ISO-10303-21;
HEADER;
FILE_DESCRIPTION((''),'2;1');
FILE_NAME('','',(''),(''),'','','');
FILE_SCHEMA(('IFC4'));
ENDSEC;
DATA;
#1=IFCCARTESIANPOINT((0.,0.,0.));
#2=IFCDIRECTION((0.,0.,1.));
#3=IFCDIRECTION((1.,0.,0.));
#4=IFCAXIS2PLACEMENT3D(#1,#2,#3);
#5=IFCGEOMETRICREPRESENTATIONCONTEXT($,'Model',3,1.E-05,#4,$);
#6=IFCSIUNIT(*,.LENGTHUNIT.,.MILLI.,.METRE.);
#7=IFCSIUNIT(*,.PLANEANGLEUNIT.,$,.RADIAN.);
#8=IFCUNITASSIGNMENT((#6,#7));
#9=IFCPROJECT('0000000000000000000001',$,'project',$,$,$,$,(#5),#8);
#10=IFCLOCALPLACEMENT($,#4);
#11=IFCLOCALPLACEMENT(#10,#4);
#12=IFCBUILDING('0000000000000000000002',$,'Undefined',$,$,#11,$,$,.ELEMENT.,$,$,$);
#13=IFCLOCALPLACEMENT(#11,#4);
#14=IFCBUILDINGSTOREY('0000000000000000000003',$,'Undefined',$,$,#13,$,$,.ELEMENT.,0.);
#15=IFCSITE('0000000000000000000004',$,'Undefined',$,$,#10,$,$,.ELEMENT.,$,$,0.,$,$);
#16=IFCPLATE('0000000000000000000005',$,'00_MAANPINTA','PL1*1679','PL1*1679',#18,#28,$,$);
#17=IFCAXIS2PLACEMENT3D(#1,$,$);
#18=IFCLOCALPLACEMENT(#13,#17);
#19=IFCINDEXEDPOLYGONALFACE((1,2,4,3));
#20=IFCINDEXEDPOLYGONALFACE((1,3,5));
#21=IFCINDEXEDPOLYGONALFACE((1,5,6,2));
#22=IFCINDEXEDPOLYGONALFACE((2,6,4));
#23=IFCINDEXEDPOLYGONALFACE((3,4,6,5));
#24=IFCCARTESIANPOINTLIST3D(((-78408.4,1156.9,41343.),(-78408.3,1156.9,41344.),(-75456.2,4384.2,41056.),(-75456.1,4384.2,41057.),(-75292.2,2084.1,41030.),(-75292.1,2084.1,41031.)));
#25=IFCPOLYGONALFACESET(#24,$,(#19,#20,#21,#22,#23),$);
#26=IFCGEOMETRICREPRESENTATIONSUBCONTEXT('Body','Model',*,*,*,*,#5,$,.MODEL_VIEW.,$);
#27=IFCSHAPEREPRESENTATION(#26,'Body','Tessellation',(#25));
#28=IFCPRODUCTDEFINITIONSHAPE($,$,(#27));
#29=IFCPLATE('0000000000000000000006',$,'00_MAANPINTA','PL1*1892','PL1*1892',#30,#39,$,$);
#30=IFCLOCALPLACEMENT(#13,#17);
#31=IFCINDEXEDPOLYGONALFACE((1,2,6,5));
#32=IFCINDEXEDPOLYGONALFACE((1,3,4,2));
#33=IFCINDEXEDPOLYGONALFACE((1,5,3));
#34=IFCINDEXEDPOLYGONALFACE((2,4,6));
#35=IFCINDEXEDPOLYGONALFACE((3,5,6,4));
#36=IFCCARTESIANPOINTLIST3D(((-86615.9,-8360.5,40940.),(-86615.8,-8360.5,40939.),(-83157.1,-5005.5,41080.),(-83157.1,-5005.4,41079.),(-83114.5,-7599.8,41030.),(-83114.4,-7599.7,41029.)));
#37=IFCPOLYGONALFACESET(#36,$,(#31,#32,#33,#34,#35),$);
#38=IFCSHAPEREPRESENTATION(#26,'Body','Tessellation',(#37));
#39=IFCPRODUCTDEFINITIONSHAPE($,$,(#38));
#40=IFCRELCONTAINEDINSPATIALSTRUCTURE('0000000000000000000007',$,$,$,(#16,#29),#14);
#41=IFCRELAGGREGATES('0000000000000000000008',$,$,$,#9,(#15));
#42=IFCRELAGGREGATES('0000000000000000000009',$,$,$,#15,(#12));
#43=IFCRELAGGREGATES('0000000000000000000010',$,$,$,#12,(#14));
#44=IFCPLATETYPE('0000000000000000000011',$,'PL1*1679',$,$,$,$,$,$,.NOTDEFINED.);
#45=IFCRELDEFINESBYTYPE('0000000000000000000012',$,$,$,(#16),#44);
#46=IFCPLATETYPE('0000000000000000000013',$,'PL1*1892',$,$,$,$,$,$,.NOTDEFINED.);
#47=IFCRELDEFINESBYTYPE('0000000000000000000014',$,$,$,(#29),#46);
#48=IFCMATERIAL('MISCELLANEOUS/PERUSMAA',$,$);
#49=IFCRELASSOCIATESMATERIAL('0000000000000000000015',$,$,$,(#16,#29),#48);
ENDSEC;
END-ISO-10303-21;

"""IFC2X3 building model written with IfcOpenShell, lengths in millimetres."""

from ifc_helpers import new_model, si_unit, frame, origin_with_axes, place, context, subcontext, project, spatial, polyline, outline, extrude, material, type_object, element, save


model = new_model("IFC2X3")

# Units and contexts
model_context = context("Model", 3, precision=1e-05, world=origin_with_axes())
body_context = subcontext(model_context, "Body", "Model", "MODEL_VIEW")
ifc_project = project(units=[si_unit("LENGTHUNIT", "METRE", prefix="MILLI"), si_unit("PLANEANGLEUNIT", "RADIAN")], contexts=[model_context])

# Site, building, storey
site_placement = place(None, origin_with_axes())
site = spatial("IfcSite", under=ifc_project, at=site_placement, Name="Undefined", CompositionType="ELEMENT", RefElevation=0.0)
building_placement = place(site_placement, origin_with_axes())
building = spatial("IfcBuilding", under=site, at=building_placement, Name="Undefined", CompositionType="ELEMENT")
storey_placement = place(building_placement, origin_with_axes())
storey = spatial("IfcBuildingStorey", under=building, at=storey_placement, Name="Undefined", CompositionType="ELEMENT", Elevation=0.0)

# Plates
ifc_material = material(Name="MISCELLANEOUS/PERUSMAA")
plate_type_1 = type_object("IfcPlateType", Name="PL1*1679", PredefinedType="NOTDEFINED")
plate_1_placement = place(storey_placement, frame((-75456.2, 4384.2, 41056.5), z_axis=(-0.101127, 0.004034, -0.994865), x_axis=(0.07113, -0.997403, -0.011275)))
element("IfcPlate", 1, at=plate_1_placement, inside=storey, type_object=plate_type_1, material=ifc_material, Name="00_MAANPINTA", Description="PL1*1679", ObjectType="PL1*1679", context=body_context, shape_type="SweptSolid", body=[
    extrude(outline(polyline([(0.0, 0.0), (2306.1, 0.0), (3005.7, 3190.4), (0.0, 0.0)])), frame((0.0, 0.0, -0.5), z_axis=(0.0, 0.0, 1.0), x_axis=(1.0, 0.0, 0.0)), (0.0, 0.0, 1.0), 1.0),
])
plate_type_2 = type_object("IfcPlateType", Name="PL1*1892", PredefinedType="NOTDEFINED")
plate_2_placement = place(storey_placement, frame((-83157.1, -5005.5, 41079.5), z_axis=(0.021431, 0.019617, -0.999578), x_axis=(0.016426, -0.999679, -0.019267)))
element("IfcPlate", 2, at=plate_2_placement, inside=storey, type_object=plate_type_2, material=ifc_material, Name="00_MAANPINTA", Description="PL1*1892", ObjectType="PL1*1892", context=body_context, shape_type="SweptSolid", body=[
    extrude(outline(polyline([(0.0, 0.0), (2595.1, 0.0), (3299.8, 3514.3), (0.0, 0.0)])), frame((0.0, 0.0, -0.5), z_axis=(0.0, 0.0, 1.0), x_axis=(1.0, 0.0, 0.0)), (0.0, 0.0, 1.0), 1.0),
])

save(model, "model.ifc")
